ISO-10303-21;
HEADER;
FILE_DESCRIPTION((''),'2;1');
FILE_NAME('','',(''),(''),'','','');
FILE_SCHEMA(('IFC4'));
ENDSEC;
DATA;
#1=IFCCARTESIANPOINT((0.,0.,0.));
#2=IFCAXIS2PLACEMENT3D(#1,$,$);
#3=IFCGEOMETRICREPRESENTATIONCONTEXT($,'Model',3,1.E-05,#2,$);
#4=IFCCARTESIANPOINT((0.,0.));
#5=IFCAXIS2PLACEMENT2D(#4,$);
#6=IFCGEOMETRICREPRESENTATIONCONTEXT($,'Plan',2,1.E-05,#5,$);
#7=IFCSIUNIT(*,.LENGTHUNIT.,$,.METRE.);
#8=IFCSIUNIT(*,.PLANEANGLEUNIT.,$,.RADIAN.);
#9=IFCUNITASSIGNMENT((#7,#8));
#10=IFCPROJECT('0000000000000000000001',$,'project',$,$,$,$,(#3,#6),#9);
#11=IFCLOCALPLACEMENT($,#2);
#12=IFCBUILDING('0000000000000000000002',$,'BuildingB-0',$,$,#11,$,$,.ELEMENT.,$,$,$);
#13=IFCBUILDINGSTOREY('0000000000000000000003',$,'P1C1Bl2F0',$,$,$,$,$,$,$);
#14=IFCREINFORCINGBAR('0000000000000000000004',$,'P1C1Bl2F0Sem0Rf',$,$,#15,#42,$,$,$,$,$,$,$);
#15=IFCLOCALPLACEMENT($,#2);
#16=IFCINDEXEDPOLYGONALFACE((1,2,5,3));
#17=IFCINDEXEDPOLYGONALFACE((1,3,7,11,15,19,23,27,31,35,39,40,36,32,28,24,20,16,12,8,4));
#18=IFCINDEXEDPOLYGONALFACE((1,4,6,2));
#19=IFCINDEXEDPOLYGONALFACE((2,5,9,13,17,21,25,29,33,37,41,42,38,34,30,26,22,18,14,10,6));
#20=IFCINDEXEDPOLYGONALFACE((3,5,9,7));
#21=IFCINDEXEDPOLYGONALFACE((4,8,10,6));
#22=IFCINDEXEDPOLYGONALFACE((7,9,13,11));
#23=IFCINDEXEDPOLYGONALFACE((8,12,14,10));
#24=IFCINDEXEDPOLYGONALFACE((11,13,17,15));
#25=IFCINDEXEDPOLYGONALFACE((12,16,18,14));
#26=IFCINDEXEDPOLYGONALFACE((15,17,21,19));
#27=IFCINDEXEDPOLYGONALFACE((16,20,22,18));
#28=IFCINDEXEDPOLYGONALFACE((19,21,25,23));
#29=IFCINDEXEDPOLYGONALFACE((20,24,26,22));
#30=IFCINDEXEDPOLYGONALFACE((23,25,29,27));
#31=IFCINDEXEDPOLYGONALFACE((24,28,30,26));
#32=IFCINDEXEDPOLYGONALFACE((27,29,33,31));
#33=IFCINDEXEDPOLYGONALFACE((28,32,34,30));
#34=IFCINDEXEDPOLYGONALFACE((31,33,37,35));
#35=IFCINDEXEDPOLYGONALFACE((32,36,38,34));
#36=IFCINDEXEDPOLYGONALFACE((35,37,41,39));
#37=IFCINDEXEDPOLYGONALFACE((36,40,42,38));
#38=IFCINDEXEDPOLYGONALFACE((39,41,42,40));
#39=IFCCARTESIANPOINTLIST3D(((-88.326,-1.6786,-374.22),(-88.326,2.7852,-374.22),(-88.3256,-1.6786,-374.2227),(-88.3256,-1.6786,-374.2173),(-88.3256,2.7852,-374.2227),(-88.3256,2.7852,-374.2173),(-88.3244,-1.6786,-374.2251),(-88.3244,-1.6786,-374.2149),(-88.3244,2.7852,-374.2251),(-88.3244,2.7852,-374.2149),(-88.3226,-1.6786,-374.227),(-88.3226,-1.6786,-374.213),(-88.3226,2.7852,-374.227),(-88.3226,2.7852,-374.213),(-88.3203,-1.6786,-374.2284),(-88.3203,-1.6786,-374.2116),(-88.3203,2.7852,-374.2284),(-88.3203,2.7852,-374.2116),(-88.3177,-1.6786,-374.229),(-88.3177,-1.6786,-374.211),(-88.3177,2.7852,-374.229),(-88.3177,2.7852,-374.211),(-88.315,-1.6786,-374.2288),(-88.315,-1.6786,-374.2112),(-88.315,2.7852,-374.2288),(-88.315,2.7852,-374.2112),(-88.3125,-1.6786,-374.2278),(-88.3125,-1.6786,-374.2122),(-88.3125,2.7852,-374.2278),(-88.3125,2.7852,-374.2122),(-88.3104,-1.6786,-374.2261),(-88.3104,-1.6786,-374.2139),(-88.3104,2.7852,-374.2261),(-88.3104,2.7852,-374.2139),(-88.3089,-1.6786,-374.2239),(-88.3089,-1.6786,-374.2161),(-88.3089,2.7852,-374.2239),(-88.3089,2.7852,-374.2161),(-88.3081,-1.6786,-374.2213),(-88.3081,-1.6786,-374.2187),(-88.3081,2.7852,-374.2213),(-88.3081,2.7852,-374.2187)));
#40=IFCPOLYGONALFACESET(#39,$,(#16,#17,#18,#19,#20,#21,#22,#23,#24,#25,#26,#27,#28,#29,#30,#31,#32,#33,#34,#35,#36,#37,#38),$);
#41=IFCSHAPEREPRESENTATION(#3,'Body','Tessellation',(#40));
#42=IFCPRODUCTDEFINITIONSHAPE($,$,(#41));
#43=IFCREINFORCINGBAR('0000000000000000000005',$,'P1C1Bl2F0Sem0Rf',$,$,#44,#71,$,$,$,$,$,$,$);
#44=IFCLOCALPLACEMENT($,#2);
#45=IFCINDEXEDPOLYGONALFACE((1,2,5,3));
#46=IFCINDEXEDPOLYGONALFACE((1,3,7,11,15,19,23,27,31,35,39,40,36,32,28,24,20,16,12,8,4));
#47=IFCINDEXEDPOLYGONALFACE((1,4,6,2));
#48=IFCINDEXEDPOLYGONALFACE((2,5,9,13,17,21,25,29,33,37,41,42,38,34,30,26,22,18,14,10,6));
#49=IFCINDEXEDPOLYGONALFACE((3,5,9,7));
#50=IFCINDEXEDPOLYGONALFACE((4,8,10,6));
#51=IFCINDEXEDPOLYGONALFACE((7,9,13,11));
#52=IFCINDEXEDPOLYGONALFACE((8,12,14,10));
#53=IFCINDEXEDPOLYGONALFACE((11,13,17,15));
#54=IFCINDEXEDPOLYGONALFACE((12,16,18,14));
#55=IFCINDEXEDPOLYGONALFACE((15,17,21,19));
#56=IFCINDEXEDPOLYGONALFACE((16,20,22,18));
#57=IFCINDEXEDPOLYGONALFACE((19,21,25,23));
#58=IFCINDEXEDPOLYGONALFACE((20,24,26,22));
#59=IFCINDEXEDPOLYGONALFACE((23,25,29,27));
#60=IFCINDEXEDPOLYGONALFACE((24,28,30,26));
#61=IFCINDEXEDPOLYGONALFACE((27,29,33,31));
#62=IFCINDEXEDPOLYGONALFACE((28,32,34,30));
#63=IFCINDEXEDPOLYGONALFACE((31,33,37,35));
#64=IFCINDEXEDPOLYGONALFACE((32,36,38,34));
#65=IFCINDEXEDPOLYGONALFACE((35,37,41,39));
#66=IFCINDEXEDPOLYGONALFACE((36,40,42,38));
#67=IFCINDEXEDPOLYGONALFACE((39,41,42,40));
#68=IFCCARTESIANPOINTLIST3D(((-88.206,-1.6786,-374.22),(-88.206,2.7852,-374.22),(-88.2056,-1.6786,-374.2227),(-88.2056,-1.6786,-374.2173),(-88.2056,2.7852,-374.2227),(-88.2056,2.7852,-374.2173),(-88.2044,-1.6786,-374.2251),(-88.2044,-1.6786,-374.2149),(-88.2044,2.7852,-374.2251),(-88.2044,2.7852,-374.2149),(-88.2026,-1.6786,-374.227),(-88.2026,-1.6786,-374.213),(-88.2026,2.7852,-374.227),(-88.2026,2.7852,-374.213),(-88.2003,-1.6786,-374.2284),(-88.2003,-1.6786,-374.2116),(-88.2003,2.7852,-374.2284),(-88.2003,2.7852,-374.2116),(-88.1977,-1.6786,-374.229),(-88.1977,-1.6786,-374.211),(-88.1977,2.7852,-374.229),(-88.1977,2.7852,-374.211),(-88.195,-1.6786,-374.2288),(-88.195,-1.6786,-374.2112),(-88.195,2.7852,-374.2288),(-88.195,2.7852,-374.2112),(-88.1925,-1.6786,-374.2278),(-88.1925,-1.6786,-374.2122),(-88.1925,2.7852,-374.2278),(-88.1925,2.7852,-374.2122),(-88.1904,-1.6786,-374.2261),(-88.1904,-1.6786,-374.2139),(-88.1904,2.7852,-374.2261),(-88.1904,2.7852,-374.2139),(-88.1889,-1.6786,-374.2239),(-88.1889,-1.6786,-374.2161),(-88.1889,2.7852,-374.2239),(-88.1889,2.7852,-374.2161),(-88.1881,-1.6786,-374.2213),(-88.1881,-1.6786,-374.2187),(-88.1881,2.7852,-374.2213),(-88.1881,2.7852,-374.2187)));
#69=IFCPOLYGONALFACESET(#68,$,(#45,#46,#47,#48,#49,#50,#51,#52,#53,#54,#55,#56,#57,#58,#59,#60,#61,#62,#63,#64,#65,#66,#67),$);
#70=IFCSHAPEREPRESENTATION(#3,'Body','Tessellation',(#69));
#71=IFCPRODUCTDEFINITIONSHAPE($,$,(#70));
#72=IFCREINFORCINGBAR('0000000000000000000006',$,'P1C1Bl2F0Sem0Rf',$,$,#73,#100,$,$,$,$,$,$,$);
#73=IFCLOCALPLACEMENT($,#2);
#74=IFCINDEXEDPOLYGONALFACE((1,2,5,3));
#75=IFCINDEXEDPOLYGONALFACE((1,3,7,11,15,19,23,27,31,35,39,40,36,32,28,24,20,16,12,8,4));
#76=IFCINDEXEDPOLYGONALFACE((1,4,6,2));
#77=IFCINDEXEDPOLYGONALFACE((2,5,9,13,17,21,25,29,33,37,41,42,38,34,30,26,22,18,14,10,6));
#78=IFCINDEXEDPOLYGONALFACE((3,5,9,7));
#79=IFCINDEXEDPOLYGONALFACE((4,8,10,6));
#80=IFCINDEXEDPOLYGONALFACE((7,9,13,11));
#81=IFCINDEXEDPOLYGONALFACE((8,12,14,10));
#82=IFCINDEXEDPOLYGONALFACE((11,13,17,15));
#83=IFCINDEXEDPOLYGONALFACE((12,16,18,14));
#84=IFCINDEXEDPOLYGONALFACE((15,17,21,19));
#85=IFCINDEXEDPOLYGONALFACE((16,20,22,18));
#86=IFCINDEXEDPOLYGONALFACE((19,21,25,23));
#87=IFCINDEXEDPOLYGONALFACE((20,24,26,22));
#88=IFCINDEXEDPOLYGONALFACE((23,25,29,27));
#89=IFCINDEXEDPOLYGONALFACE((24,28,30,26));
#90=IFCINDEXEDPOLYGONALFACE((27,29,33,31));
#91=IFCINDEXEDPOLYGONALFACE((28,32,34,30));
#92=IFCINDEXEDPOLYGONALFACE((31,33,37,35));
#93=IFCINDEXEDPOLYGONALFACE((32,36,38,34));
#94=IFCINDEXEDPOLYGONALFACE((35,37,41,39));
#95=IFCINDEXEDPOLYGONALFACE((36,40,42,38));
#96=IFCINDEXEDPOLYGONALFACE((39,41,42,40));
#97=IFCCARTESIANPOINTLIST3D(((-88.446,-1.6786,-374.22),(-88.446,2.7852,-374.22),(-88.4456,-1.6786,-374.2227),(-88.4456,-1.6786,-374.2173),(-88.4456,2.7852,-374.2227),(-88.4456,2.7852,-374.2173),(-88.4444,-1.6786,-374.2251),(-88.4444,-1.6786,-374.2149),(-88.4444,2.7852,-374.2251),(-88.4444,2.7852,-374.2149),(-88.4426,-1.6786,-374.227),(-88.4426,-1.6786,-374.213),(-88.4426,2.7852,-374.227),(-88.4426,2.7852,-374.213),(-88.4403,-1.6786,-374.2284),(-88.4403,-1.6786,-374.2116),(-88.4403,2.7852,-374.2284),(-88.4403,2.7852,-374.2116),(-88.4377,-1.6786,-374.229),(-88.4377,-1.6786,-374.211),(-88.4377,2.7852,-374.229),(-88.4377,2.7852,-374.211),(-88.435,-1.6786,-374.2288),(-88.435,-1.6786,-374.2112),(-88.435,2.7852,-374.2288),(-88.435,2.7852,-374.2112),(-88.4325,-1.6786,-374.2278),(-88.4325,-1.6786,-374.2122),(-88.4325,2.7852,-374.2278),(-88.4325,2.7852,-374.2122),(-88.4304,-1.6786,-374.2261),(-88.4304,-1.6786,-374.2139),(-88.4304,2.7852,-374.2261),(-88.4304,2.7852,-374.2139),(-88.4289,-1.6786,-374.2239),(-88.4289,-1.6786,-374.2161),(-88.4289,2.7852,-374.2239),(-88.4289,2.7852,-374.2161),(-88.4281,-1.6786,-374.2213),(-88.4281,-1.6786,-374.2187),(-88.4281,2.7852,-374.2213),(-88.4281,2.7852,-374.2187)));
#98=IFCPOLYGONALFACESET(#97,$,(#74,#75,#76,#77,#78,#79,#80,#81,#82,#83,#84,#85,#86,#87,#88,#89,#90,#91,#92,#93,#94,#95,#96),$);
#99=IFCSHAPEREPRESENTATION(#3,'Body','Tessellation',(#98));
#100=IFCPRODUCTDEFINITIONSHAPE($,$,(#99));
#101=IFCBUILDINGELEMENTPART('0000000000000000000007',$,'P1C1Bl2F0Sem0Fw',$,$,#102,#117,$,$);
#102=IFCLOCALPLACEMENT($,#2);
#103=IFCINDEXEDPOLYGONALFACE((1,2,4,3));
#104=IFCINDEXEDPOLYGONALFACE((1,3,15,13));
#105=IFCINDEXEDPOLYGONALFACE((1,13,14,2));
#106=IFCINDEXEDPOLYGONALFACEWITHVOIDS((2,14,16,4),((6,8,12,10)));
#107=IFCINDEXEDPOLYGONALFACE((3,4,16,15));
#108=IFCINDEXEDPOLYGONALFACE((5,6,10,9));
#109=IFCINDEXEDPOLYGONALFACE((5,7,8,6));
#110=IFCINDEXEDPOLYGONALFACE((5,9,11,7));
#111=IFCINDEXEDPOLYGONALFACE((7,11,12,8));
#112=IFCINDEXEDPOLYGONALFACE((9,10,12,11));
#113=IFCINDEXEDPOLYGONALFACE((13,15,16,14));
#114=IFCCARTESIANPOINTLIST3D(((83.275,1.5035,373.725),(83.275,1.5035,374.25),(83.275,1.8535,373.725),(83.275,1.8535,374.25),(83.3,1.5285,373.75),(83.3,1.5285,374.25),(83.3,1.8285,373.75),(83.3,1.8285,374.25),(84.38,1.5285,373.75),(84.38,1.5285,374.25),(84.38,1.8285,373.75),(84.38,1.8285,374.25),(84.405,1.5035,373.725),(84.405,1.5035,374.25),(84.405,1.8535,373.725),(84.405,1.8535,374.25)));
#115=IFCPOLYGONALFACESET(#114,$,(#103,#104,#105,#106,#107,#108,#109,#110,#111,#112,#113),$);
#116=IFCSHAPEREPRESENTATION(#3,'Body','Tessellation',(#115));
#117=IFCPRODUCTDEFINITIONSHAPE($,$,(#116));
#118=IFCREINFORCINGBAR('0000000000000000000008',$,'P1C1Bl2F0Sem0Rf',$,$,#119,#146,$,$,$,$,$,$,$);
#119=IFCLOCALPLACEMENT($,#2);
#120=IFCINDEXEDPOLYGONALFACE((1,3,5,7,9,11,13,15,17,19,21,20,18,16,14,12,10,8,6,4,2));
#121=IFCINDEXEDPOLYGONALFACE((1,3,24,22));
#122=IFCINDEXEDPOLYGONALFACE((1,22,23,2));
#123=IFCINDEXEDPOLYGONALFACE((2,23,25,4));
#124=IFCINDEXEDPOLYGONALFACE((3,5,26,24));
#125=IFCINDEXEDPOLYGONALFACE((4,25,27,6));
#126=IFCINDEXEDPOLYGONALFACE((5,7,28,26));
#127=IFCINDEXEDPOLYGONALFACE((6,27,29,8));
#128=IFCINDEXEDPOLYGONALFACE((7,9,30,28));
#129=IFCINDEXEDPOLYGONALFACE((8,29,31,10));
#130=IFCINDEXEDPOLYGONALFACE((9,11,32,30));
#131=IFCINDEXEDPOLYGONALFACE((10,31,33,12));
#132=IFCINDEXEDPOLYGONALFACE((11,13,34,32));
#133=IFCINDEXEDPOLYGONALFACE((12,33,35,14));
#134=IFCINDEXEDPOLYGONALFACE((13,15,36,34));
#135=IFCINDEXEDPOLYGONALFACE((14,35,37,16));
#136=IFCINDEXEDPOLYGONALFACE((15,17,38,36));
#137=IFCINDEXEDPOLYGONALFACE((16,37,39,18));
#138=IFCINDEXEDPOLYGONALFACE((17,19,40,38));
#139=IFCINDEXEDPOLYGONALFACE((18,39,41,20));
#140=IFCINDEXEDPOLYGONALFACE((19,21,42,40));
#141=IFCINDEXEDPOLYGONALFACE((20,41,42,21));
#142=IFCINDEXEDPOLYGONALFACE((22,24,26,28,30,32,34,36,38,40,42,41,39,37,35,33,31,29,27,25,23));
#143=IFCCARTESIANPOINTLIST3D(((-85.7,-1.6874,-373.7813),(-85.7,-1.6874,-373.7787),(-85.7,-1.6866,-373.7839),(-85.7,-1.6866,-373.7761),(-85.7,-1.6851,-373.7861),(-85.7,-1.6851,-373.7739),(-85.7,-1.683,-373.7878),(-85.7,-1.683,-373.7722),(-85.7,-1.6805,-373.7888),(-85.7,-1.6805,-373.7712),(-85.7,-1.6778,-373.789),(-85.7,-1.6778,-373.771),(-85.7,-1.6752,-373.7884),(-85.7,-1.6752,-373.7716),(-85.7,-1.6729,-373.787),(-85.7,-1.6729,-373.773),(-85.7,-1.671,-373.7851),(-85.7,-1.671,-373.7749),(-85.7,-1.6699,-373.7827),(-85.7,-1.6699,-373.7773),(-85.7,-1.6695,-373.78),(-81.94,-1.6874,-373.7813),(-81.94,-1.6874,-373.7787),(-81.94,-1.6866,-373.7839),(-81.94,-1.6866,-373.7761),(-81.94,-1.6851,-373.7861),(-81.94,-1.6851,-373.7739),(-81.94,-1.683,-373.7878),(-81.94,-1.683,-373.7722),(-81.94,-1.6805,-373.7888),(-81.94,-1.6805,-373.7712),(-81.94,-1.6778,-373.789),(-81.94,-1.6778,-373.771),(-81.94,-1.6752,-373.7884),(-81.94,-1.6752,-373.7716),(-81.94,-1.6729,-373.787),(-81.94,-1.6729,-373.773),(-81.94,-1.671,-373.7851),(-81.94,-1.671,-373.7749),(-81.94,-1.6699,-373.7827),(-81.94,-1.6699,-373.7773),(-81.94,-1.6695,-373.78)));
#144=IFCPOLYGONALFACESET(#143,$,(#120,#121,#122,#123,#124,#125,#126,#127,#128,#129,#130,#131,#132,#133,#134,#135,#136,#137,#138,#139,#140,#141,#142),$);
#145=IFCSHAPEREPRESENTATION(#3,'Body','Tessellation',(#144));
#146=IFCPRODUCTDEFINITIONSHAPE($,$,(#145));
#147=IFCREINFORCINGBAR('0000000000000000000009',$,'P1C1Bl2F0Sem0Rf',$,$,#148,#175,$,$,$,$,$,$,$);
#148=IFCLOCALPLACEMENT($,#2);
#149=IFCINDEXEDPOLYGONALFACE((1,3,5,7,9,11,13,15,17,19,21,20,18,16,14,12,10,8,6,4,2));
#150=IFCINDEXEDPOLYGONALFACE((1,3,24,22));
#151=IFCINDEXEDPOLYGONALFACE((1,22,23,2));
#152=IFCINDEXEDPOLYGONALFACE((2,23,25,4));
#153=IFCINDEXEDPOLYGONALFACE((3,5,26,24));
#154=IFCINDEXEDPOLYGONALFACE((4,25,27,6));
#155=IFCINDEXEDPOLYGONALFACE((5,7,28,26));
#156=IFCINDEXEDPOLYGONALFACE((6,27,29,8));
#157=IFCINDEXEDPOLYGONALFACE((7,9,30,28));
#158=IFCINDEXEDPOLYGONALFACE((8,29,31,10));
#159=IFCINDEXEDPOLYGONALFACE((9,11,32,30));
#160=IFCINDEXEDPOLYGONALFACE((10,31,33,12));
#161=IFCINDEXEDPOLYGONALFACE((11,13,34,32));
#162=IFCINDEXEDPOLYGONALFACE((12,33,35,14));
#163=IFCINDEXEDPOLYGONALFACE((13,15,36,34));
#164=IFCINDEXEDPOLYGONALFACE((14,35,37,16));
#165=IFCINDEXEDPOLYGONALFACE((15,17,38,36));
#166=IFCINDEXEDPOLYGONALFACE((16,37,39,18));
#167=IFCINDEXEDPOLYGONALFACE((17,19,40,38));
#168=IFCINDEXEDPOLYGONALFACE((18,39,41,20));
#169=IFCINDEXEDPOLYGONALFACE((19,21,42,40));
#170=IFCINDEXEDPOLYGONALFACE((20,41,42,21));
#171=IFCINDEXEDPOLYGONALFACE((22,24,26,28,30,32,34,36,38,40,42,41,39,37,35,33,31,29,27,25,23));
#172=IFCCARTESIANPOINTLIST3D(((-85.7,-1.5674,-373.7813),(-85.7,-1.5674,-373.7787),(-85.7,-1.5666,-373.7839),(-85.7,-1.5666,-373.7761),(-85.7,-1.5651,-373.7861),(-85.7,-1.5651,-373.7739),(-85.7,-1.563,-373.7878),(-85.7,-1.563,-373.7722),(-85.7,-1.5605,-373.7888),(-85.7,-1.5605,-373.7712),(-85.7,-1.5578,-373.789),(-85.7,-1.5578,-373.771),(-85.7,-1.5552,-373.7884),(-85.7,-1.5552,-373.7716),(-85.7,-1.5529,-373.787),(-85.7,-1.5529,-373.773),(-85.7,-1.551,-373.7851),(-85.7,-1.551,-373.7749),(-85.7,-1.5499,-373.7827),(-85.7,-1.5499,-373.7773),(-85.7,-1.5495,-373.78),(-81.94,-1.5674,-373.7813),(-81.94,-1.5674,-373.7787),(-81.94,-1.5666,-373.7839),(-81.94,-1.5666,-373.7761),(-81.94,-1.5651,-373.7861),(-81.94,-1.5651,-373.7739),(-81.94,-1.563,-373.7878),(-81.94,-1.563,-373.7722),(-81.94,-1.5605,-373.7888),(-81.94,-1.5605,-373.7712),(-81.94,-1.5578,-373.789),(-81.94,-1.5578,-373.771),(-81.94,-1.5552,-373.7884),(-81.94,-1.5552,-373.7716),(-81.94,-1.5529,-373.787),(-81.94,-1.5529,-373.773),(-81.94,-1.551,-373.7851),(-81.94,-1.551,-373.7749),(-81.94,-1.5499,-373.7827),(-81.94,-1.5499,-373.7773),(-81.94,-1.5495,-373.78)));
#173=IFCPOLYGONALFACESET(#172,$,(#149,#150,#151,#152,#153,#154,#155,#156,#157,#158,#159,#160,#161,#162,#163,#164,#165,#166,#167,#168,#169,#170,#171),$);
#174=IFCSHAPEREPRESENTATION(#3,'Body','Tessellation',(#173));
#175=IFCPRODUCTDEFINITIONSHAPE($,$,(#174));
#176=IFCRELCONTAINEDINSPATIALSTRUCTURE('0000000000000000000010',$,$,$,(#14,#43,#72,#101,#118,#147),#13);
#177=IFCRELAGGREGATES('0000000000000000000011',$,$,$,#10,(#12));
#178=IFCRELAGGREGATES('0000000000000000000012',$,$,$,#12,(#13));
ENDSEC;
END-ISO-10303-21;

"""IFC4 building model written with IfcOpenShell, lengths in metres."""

from ifc_helpers import new_model, entity, si_unit, origin, origin_2d, place, context, project, spatial, polyline, outline, extrude, element, save


model = new_model("IFC4")

# Units and contexts
model_context = context("Model", 3, precision=1e-05, world=origin())
plan_context = context("Plan", 2, precision=1e-05, world=origin_2d())
ifc_project = project(units=[si_unit("LENGTHUNIT", "METRE"), si_unit("PLANEANGLEUNIT", "RADIAN")], contexts=[model_context, plan_context])

# Building, storey
building_placement = place(None, origin())
building = spatial("IfcBuilding", under=ifc_project, at=building_placement, Name="BuildingB-0", CompositionType="ELEMENT")
storey = spatial("IfcBuildingStorey", under=building, Name="P1C1Bl2F0")

# Reinforcing bars
element("IfcReinforcingBar", 1, inside=storey, Name="P1C1Bl2F0Sem0Rf", context=model_context, shape_type="SweptSolid", body=[
    entity("IfcSurfaceCurveSweptAreaSolid", entity("IfcCircleProfileDef", "AREA", None, None, 0.009), None, entity("IfcPolyline", [entity("IfcCartesianPoint", [88.317, 1.6786, 374.22]), entity("IfcCartesianPoint", [88.317, -2.7852, 374.22])]), None, None, entity("IfcPlane", entity("IfcAxis2Placement3D", entity("IfcCartesianPoint", [88.317, 1.6786, 374.22]), entity("IfcDirection", [0.0, 0.0, 1.0]), entity("IfcDirection", [1.0, 0.0, 0.0])))),
])
element("IfcReinforcingBar", 2, inside=storey, Name="P1C1Bl2F0Sem0Rf", context=model_context, shape_type="SweptSolid", body=[
    entity("IfcSurfaceCurveSweptAreaSolid", entity("IfcCircleProfileDef", "AREA", None, None, 0.009), None, entity("IfcPolyline", [entity("IfcCartesianPoint", [88.197, 1.6786, 374.22]), entity("IfcCartesianPoint", [88.197, -2.7852, 374.22])]), None, None, entity("IfcPlane", entity("IfcAxis2Placement3D", entity("IfcCartesianPoint", [88.197, 1.6786, 374.22]), entity("IfcDirection", [0.0, 0.0, 1.0]), entity("IfcDirection", [1.0, 0.0, 0.0])))),
])
element("IfcReinforcingBar", 3, inside=storey, Name="P1C1Bl2F0Sem0Rf", context=model_context, shape_type="SweptSolid", body=[
    entity("IfcSurfaceCurveSweptAreaSolid", entity("IfcCircleProfileDef", "AREA", None, None, 0.009), None, entity("IfcPolyline", [entity("IfcCartesianPoint", [88.437, 1.6786, 374.22]), entity("IfcCartesianPoint", [88.437, -2.7852, 374.22])]), None, None, entity("IfcPlane", entity("IfcAxis2Placement3D", entity("IfcCartesianPoint", [88.437, 1.6786, 374.22]), entity("IfcDirection", [0.0, 0.0, 1.0]), entity("IfcDirection", [1.0, 0.0, 0.0])))),
])

# Building element part, opening
building_element_part_1 = element("IfcBuildingElementPart", 4, inside=storey, Name="P1C1Bl2F0Sem0Fw", context=model_context, shape_type="SweptSolid", body=[
    extrude(outline(polyline([(84.405, 1.5035, 373.725), (84.405, 1.8535, 373.725), (83.275, 1.8535, 373.725), (83.275, 1.5035, 373.725), (84.405, 1.5035, 373.725)])), None, (0.0, 0.0, 1.0), 0.525),
])
element("IfcOpeningElement", 5, inside=storey, cuts=building_element_part_1, context=model_context, shape_type="SweptSolid", body=[
    extrude(outline(polyline([(84.38, 1.5285, 373.75), (84.38, 1.8285, 373.75), (83.3, 1.8285, 373.75), (83.3, 1.5285, 373.75), (84.38, 1.5285, 373.75)])), None, (0.0, 0.0, 1.0), 0.5),
])

# Reinforcing bars
element("IfcReinforcingBar", 6, inside=storey, Name="P1C1Bl2F0Sem0Rf", context=model_context, shape_type="SweptSolid", body=[
    entity("IfcSurfaceCurveSweptAreaSolid", entity("IfcCircleProfileDef", "AREA", None, None, 0.009), None, entity("IfcPolyline", [entity("IfcCartesianPoint", [81.94, 1.6785, 373.78]), entity("IfcCartesianPoint", [85.7, 1.6785, 373.78])]), None, None, entity("IfcPlane", entity("IfcAxis2Placement3D", entity("IfcCartesianPoint", [81.94, 1.6785, 373.78]), entity("IfcDirection", [0.0, 0.0, 1.0]), entity("IfcDirection", [1.0, 0.0, 0.0])))),
])
element("IfcReinforcingBar", 7, inside=storey, Name="P1C1Bl2F0Sem0Rf", context=model_context, shape_type="SweptSolid", body=[
    entity("IfcSurfaceCurveSweptAreaSolid", entity("IfcCircleProfileDef", "AREA", None, None, 0.009), None, entity("IfcPolyline", [entity("IfcCartesianPoint", [81.94, 1.5585, 373.78]), entity("IfcCartesianPoint", [85.7, 1.5585, 373.78])]), None, None, entity("IfcPlane", entity("IfcAxis2Placement3D", entity("IfcCartesianPoint", [81.94, 1.5585, 373.78]), entity("IfcDirection", [0.0, 0.0, 1.0]), entity("IfcDirection", [1.0, 0.0, 0.0])))),
])

save(model, "model.ifc")
